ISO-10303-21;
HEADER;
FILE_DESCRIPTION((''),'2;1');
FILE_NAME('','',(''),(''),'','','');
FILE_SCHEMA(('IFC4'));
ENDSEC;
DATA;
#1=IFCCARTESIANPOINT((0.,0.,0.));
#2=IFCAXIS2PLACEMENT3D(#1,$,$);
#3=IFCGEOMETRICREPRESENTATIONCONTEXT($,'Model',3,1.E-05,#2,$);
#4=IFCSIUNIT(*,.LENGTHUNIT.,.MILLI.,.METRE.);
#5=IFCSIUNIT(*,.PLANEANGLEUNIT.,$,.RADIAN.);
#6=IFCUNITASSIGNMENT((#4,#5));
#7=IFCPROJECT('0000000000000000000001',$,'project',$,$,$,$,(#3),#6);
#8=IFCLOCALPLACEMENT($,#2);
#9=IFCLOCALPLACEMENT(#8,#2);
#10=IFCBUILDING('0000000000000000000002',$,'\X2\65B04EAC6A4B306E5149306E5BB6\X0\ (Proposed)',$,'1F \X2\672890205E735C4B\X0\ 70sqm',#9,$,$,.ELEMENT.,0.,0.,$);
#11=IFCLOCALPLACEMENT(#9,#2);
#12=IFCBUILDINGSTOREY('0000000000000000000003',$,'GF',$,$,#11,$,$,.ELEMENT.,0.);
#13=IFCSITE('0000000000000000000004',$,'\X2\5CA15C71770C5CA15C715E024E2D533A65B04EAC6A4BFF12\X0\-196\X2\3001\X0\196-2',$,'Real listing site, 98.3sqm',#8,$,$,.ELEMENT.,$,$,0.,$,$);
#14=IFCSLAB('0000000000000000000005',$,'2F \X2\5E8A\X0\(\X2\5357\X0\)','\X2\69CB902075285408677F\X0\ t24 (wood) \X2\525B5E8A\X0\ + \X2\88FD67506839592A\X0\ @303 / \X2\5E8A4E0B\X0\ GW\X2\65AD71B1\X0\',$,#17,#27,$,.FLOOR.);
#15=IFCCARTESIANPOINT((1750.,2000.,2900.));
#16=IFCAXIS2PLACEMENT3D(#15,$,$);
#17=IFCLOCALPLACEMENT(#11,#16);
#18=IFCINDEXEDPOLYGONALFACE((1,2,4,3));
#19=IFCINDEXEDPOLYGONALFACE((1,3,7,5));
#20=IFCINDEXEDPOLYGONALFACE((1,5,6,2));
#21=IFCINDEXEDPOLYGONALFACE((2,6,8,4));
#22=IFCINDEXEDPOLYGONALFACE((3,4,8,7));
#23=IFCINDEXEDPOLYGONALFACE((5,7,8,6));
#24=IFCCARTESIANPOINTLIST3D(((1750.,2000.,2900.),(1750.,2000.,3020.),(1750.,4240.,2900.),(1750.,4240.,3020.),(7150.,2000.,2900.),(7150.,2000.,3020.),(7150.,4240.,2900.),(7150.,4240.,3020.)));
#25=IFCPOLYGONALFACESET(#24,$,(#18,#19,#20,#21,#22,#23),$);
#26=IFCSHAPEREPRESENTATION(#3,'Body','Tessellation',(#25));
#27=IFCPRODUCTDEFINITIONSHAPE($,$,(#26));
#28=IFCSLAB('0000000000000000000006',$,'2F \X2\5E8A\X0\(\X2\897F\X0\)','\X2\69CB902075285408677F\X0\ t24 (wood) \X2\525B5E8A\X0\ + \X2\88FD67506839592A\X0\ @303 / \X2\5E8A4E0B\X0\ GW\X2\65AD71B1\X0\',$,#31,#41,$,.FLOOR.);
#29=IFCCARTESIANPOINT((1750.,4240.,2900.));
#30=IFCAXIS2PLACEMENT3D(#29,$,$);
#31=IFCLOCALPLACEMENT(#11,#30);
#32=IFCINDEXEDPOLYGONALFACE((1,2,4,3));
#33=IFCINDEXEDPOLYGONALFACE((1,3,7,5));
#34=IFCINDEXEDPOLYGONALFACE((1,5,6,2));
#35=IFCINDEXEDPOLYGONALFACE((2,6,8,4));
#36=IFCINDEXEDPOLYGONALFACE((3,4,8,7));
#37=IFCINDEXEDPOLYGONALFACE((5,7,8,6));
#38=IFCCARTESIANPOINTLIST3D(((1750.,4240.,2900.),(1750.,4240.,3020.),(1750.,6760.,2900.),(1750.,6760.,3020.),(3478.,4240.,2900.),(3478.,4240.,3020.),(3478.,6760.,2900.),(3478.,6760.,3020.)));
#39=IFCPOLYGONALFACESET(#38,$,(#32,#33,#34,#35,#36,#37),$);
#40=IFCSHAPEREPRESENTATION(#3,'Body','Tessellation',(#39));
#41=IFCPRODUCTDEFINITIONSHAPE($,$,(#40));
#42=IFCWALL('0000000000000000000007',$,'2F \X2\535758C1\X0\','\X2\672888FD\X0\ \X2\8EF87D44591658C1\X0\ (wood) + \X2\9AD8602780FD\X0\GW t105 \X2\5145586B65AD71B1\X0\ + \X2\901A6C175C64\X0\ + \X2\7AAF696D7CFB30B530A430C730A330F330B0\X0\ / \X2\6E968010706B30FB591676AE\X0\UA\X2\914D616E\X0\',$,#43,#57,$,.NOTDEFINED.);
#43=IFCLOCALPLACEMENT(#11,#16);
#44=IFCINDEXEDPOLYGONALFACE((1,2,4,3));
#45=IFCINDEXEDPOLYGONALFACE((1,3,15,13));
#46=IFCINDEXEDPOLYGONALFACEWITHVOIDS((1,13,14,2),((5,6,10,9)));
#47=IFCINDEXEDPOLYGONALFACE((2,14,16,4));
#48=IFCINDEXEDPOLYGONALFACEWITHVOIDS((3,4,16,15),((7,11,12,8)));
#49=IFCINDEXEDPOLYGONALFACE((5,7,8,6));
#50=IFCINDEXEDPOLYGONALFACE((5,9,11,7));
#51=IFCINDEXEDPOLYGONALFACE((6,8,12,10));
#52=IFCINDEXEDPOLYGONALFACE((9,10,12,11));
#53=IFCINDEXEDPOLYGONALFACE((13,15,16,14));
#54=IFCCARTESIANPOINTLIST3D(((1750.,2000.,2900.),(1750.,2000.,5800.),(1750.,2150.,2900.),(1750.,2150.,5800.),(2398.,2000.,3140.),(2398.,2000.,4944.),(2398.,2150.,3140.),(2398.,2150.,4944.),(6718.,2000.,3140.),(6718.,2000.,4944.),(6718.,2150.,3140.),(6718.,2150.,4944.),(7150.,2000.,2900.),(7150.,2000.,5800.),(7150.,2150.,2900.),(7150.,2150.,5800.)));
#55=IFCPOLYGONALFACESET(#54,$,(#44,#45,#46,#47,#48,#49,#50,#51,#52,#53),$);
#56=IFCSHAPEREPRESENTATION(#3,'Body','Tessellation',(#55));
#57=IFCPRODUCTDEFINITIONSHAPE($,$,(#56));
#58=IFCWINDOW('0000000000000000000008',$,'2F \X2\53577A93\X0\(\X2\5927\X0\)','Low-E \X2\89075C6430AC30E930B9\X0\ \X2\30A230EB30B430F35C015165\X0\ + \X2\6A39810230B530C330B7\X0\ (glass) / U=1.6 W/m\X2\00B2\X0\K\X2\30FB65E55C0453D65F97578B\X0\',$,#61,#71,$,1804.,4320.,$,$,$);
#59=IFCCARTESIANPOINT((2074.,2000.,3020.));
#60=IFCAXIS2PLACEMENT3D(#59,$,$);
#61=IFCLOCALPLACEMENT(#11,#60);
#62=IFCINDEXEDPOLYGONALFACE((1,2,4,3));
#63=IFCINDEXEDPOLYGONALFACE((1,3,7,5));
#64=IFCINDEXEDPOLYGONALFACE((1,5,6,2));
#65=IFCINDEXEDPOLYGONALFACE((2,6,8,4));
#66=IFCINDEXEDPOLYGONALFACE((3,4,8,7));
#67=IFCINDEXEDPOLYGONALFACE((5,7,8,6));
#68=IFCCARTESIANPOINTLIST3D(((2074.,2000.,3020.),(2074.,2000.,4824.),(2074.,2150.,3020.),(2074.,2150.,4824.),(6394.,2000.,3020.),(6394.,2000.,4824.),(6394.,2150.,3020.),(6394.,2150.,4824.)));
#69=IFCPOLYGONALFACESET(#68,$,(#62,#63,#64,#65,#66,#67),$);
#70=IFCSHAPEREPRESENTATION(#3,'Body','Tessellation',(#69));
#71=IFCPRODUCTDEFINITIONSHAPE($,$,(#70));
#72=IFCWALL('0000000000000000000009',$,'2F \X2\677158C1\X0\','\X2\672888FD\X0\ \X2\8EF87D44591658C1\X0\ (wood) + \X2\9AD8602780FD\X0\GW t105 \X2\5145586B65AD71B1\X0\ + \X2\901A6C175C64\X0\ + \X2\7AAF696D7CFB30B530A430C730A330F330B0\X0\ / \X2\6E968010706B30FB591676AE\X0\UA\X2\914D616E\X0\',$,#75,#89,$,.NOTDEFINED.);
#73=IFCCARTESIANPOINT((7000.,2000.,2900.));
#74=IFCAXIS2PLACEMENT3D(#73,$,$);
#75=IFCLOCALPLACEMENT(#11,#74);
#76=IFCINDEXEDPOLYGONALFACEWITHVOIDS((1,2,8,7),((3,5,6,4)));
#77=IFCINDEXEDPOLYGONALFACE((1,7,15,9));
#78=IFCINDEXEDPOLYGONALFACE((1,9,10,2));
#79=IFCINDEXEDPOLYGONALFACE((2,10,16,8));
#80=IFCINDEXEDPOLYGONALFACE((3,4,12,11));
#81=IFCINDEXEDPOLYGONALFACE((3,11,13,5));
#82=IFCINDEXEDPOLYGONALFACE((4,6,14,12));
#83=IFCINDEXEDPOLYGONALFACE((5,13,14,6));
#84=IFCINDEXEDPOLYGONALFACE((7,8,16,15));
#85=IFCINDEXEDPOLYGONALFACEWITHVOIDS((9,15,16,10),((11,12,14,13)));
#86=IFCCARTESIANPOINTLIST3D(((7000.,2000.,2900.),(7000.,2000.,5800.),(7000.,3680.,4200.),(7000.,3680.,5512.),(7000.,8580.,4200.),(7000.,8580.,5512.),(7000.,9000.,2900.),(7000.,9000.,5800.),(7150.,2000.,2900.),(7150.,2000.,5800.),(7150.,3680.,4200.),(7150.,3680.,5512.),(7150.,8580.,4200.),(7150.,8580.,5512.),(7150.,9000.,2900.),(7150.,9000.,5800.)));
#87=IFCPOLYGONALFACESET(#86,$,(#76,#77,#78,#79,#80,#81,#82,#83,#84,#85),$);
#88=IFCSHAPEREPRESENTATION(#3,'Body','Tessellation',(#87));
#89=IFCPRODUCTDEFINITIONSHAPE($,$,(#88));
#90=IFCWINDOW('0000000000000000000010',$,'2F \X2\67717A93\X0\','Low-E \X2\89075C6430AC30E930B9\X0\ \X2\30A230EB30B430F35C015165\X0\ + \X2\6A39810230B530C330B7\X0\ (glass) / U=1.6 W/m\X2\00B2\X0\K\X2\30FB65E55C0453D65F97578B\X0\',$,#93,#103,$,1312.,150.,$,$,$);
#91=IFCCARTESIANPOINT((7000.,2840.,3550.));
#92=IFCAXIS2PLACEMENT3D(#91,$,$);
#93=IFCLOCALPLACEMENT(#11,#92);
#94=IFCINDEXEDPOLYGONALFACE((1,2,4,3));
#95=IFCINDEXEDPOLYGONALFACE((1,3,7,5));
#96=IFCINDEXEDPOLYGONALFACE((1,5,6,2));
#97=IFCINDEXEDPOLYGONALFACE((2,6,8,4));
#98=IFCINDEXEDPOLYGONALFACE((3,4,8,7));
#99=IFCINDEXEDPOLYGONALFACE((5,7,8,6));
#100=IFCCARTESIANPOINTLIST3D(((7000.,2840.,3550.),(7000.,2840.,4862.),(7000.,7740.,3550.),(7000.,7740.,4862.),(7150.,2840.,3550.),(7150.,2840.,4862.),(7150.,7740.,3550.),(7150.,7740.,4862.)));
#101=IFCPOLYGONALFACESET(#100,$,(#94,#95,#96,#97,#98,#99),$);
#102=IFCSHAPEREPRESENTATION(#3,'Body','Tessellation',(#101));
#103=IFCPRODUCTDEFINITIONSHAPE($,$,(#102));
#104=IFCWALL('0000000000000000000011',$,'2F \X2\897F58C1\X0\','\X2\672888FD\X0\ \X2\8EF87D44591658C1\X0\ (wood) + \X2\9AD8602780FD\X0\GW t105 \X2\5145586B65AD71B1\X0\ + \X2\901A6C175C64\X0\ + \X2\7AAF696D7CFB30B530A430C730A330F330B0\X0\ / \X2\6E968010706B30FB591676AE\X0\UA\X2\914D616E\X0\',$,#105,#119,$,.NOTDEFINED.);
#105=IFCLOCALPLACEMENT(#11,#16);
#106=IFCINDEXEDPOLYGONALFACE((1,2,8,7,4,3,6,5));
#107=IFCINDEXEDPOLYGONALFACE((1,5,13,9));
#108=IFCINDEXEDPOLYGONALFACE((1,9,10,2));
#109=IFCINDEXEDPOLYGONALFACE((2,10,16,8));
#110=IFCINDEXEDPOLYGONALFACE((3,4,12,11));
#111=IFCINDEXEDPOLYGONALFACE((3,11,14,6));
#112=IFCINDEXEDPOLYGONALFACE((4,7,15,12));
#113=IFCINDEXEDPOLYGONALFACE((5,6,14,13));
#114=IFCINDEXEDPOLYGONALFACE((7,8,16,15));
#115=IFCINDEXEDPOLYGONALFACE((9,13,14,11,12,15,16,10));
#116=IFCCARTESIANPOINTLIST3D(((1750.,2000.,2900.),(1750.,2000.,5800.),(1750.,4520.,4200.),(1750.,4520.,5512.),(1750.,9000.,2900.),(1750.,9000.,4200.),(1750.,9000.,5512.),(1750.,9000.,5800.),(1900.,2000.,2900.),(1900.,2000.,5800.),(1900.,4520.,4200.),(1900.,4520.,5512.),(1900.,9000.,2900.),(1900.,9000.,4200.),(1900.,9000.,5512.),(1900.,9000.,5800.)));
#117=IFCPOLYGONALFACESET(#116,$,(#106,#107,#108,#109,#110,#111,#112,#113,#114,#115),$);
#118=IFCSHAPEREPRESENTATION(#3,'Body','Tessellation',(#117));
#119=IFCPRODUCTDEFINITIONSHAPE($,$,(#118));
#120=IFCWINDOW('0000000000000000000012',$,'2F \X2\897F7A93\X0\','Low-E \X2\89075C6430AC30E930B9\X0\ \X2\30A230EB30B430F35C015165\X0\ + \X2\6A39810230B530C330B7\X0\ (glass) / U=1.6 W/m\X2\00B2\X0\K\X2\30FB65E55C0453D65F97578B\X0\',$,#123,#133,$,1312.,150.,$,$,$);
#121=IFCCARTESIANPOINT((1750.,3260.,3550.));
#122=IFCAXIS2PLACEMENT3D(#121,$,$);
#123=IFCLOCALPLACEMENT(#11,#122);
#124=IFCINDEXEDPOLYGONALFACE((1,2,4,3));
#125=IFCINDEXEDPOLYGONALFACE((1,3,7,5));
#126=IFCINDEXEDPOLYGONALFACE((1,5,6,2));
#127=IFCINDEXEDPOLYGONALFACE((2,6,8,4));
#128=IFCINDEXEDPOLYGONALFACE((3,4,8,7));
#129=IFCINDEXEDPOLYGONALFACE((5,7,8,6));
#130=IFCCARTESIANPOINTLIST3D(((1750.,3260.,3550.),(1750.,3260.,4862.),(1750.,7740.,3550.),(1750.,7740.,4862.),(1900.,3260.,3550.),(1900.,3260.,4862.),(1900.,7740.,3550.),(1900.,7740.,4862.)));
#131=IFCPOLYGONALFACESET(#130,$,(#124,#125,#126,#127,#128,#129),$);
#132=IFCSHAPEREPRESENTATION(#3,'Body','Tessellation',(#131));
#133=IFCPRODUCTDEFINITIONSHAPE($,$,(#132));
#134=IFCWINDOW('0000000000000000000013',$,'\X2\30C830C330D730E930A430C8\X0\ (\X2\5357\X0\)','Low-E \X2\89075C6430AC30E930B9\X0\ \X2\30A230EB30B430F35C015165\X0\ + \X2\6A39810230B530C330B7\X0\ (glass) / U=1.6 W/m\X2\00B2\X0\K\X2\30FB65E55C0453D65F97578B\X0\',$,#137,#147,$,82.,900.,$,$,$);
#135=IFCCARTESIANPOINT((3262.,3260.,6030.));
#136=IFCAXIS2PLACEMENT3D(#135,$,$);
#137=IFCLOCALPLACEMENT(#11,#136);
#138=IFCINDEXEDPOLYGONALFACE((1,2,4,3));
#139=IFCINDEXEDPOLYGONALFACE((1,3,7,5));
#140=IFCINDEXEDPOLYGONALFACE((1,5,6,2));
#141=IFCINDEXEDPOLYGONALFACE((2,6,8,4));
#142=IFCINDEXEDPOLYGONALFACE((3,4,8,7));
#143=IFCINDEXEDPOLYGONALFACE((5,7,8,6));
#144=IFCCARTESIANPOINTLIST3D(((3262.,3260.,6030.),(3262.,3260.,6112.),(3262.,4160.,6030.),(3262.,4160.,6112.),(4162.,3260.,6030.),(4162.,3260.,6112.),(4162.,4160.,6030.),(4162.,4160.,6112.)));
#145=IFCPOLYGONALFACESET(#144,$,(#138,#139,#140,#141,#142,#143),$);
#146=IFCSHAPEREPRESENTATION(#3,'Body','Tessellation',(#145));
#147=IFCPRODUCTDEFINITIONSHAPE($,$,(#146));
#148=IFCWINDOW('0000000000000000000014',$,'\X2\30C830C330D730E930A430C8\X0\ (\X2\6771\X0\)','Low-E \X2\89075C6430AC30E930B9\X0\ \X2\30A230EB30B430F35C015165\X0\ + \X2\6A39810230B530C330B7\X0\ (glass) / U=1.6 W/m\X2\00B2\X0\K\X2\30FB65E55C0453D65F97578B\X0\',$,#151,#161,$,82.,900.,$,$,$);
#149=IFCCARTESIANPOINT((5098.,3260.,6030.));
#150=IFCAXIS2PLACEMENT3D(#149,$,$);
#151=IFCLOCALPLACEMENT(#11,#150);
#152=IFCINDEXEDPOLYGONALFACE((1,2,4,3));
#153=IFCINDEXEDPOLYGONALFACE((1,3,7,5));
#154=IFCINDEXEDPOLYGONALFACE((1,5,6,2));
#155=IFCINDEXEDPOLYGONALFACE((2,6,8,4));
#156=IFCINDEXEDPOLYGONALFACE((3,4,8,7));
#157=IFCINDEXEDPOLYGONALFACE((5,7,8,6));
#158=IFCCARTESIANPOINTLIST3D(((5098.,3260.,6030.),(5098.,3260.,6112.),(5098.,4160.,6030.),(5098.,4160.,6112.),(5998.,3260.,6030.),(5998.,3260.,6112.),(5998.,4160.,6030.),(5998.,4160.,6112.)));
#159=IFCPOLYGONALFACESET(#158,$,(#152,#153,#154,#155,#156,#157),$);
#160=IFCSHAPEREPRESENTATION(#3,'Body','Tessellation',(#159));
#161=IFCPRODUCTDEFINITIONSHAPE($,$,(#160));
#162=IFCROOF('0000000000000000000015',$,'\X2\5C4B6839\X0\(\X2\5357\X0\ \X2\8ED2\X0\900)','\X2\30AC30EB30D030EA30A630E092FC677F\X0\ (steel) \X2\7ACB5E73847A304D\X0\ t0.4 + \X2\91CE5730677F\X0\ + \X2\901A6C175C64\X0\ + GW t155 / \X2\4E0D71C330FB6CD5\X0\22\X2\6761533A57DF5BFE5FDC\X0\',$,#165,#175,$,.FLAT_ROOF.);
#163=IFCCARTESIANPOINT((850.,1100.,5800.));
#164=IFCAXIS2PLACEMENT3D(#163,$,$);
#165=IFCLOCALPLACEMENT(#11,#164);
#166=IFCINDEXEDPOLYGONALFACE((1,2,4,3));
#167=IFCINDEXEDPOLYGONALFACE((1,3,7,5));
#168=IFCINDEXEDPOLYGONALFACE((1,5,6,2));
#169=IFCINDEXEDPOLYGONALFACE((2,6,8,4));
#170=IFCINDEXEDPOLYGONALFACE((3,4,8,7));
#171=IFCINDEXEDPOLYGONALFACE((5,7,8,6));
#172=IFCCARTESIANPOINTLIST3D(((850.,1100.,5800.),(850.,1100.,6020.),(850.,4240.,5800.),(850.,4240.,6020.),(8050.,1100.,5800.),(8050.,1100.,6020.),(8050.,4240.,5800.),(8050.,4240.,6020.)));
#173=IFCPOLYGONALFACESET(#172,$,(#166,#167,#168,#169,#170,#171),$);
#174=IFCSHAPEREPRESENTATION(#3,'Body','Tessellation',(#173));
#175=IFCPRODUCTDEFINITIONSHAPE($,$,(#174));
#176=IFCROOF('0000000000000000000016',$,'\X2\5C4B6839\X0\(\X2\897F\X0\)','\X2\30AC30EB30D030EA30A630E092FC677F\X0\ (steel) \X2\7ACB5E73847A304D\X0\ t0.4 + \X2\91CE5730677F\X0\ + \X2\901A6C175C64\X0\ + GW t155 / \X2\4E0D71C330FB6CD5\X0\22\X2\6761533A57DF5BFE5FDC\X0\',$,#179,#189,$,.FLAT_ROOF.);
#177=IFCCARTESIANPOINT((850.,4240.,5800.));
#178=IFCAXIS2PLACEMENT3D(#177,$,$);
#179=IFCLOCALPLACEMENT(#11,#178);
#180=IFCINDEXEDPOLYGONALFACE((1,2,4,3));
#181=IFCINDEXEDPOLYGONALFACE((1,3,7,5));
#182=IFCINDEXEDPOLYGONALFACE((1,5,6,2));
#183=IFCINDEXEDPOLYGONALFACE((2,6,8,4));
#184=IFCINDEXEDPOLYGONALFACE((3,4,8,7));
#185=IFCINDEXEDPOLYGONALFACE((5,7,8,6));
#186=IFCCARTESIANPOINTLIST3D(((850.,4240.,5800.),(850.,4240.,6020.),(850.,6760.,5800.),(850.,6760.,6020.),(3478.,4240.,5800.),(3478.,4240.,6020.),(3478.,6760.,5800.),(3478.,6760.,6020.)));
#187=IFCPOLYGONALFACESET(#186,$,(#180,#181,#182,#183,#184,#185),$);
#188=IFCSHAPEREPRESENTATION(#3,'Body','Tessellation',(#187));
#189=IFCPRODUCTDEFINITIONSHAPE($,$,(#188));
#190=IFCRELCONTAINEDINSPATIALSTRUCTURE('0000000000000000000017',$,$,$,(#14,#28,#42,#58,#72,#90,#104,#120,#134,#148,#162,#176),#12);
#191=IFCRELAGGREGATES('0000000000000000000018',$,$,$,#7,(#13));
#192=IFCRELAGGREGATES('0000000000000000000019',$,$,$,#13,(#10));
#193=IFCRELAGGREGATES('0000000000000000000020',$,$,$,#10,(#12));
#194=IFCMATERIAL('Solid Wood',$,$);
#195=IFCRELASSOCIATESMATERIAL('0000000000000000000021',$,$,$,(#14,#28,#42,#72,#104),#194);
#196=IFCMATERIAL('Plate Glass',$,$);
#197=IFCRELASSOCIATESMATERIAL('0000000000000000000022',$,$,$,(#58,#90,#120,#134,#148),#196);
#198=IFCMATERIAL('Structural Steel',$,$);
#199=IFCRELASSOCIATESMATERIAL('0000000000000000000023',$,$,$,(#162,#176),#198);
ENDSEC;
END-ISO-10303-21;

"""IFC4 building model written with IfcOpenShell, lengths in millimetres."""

from ifc_helpers import new_model, si_unit, frame, frame_2d, origin, place, context, project, spatial, rectangle, extrude, material, element, fill, save


model = new_model("IFC4")

# Units and contexts
model_context = context("Model", 3, precision=1e-05, world=origin())
ifc_project = project(units=[si_unit("LENGTHUNIT", "METRE", prefix="MILLI"), si_unit("PLANEANGLEUNIT", "RADIAN")], contexts=[model_context])

# Site, building, storey
site_placement = place(None, origin())
site = spatial("IfcSite", under=ifc_project, at=site_placement, Name="岡山県岡山市中区新京橋２-196、196-2", ObjectType="Real listing site, 98.3sqm", CompositionType="ELEMENT", RefElevation=0.0)
building_placement = place(site_placement, origin())
building = spatial("IfcBuilding", under=site, at=building_placement, Name="新京橋の光の家 (Proposed)", ObjectType="1F 木造平屋 70sqm", CompositionType="ELEMENT", ElevationOfRefHeight=0.0, ElevationOfTerrain=0.0)
storey_placement = place(building_placement, origin())
storey = spatial("IfcBuildingStorey", under=building, at=storey_placement, Name="GF", CompositionType="ELEMENT", Elevation=0.0)

# Slabs
ifc_material_1 = material(Name="Solid Wood")
slab_1_placement = place(storey_placement, frame((1750.0, 2000.0, 2900.0)))
element("IfcSlab", 1, at=slab_1_placement, inside=storey, material=ifc_material_1, Name="2F 床(南)", Description="構造用合板 t24 (wood) 剛床 + 製材根太 @303 / 床下 GW断熱", PredefinedType="FLOOR", context=model_context, shape_type="SweptSolid", body=[
    extrude(rectangle(XDim=5400.0, YDim=2240.0, at=frame_2d((2700.0, 1120.0))), frame((1750.0, 2000.0, 2900.0)), (0.0, 0.0, 1.0), 120.0),
])
slab_2_placement = place(storey_placement, frame((1750.0, 4240.0, 2900.0)))
element("IfcSlab", 2, at=slab_2_placement, inside=storey, material=ifc_material_1, Name="2F 床(西)", Description="構造用合板 t24 (wood) 剛床 + 製材根太 @303 / 床下 GW断熱", PredefinedType="FLOOR", context=model_context, shape_type="SweptSolid", body=[
    extrude(rectangle(XDim=1728.0, YDim=2520.0, at=frame_2d((864.0, 1260.0))), frame((1750.0, 4240.0, 2900.0)), (0.0, 0.0, 1.0), 120.0),
])

# Walls, openings, windows
wall_1_placement = place(storey_placement, frame((1750.0, 2000.0, 2900.0)))
wall_1 = element("IfcWall", 3, at=wall_1_placement, inside=storey, material=ifc_material_1, Name="2F 南壁", Description="木製 軸組外壁 (wood) + 高性能GW t105 充填断熱 + 通気層 + 窯業系サイディング / 準耐火・外皮UA配慮", PredefinedType="NOTDEFINED", context=model_context, shape_type="SweptSolid", body=[
    extrude(rectangle(XDim=5400.0, YDim=150.0, at=frame_2d((2700.0, 75.0))), frame((1750.0, 2000.0, 2900.0)), (0.0, 0.0, 1.0), 2900.0),
])
opening_1_placement = place(storey_placement, frame((2074.0, 2000.0, 3020.0)))
opening_1 = element("IfcOpeningElement", 4, at=opening_1_placement, cuts=wall_1, PredefinedType="NOTDEFINED", context=model_context, shape_type="SweptSolid", body=[
    extrude(rectangle(XDim=4320.0, YDim=150.0, at=frame_2d((2160.0, 75.0))), frame((2074.0, 2000.0, 3020.0)), (0.0, 0.0, 1.0), 1804.0),
])
ifc_material_2 = material(Name="Plate Glass")
window_1_placement = place(storey_placement, frame((2074.0, 2000.0, 3020.0)))
window_1 = element("IfcWindow", 5, at=window_1_placement, inside=storey, material=ifc_material_2, Name="2F 南窓(大)", Description="Low-E 複層ガラス アルゴン封入 + 樹脂サッシ (glass) / U=1.6 W/m²K・日射取得型", OverallHeight=1804.0, OverallWidth=4320.0, context=model_context, shape_type="SweptSolid", body=[
    extrude(rectangle(XDim=4320.0, YDim=150.0, at=frame_2d((2160.0, 75.0))), frame((2074.0, 2000.0, 3020.0)), (0.0, 0.0, 1.0), 1804.0),
])
fill(opening_1, window_1)
wall_2_placement = place(storey_placement, frame((7000.0, 2000.0, 2900.0)))
wall_2 = element("IfcWall", 6, at=wall_2_placement, inside=storey, material=ifc_material_1, Name="2F 東壁", Description="木製 軸組外壁 (wood) + 高性能GW t105 充填断熱 + 通気層 + 窯業系サイディング / 準耐火・外皮UA配慮", PredefinedType="NOTDEFINED", context=model_context, shape_type="SweptSolid", body=[
    extrude(rectangle(XDim=150.0, YDim=7000.0, at=frame_2d((75.0, 3500.0))), frame((7000.0, 2000.0, 2900.0)), (0.0, 0.0, 1.0), 2900.0),
])
opening_2_placement = place(storey_placement, frame((7000.0, 2840.0, 3550.0)))
opening_2 = element("IfcOpeningElement", 7, at=opening_2_placement, cuts=wall_2, PredefinedType="NOTDEFINED", context=model_context, shape_type="SweptSolid", body=[
    extrude(rectangle(XDim=150.0, YDim=4900.0, at=frame_2d((75.0, 2450.0))), frame((7000.0, 2840.0, 3550.0)), (0.0, 0.0, 1.0), 1312.0),
])
window_2_placement = place(storey_placement, frame((7000.0, 2840.0, 3550.0)))
window_2 = element("IfcWindow", 8, at=window_2_placement, inside=storey, material=ifc_material_2, Name="2F 東窓", Description="Low-E 複層ガラス アルゴン封入 + 樹脂サッシ (glass) / U=1.6 W/m²K・日射取得型", OverallHeight=1312.0, OverallWidth=150.0, context=model_context, shape_type="SweptSolid", body=[
    extrude(rectangle(XDim=150.0, YDim=4900.0, at=frame_2d((75.0, 2450.0))), frame((7000.0, 2840.0, 3550.0)), (0.0, 0.0, 1.0), 1312.0),
])
fill(opening_2, window_2)
wall_3_placement = place(storey_placement, frame((1750.0, 2000.0, 2900.0)))
wall_3 = element("IfcWall", 9, at=wall_3_placement, inside=storey, material=ifc_material_1, Name="2F 西壁", Description="木製 軸組外壁 (wood) + 高性能GW t105 充填断熱 + 通気層 + 窯業系サイディング / 準耐火・外皮UA配慮", PredefinedType="NOTDEFINED", context=model_context, shape_type="SweptSolid", body=[
    extrude(rectangle(XDim=150.0, YDim=7000.0, at=frame_2d((75.0, 3500.0))), frame((1750.0, 2000.0, 2900.0)), (0.0, 0.0, 1.0), 2900.0),
])
opening_3_placement = place(storey_placement, frame((1750.0, 3260.0, 3550.0)))
opening_3 = element("IfcOpeningElement", 10, at=opening_3_placement, cuts=wall_3, PredefinedType="NOTDEFINED", context=model_context, shape_type="SweptSolid", body=[
    extrude(rectangle(XDim=150.0, YDim=4480.0, at=frame_2d((75.0, 2240.0))), frame((1750.0, 3260.0, 3550.0)), (0.0, 0.0, 1.0), 1312.0),
])
window_3_placement = place(storey_placement, frame((1750.0, 3260.0, 3550.0)))
window_3 = element("IfcWindow", 11, at=window_3_placement, inside=storey, material=ifc_material_2, Name="2F 西窓", Description="Low-E 複層ガラス アルゴン封入 + 樹脂サッシ (glass) / U=1.6 W/m²K・日射取得型", OverallHeight=1312.0, OverallWidth=150.0, context=model_context, shape_type="SweptSolid", body=[
    extrude(rectangle(XDim=150.0, YDim=4480.0, at=frame_2d((75.0, 2240.0))), frame((1750.0, 3260.0, 3550.0)), (0.0, 0.0, 1.0), 1312.0),
])
fill(opening_3, window_3)

# Windows
window_4_placement = place(storey_placement, frame((3262.0, 3260.0, 6030.0)))
element("IfcWindow", 12, at=window_4_placement, inside=storey, material=ifc_material_2, Name="トップライト (南)", Description="Low-E 複層ガラス アルゴン封入 + 樹脂サッシ (glass) / U=1.6 W/m²K・日射取得型", OverallHeight=82.0, OverallWidth=900.0, context=model_context, shape_type="SweptSolid", body=[
    extrude(rectangle(XDim=900.0, YDim=900.0, at=frame_2d((450.0, 450.0))), frame((3262.0, 3260.0, 6030.0)), (0.0, 0.0, 1.0), 82.0),
])
window_5_placement = place(storey_placement, frame((5098.0, 3260.0, 6030.0)))
element("IfcWindow", 13, at=window_5_placement, inside=storey, material=ifc_material_2, Name="トップライト (東)", Description="Low-E 複層ガラス アルゴン封入 + 樹脂サッシ (glass) / U=1.6 W/m²K・日射取得型", OverallHeight=82.0, OverallWidth=900.0, context=model_context, shape_type="SweptSolid", body=[
    extrude(rectangle(XDim=900.0, YDim=900.0, at=frame_2d((450.0, 450.0))), frame((5098.0, 3260.0, 6030.0)), (0.0, 0.0, 1.0), 82.0),
])

# Roofs
ifc_material_3 = material(Name="Structural Steel")
roof_1_placement = place(storey_placement, frame((850.0, 1100.0, 5800.0)))
element("IfcRoof", 14, at=roof_1_placement, inside=storey, material=ifc_material_3, Name="屋根(南 軒900)", Description="ガルバリウム鋼板 (steel) 立平葺き t0.4 + 野地板 + 通気層 + GW t155 / 不燃・法22条区域対応", PredefinedType="FLAT_ROOF", context=model_context, shape_type="SweptSolid", body=[
    extrude(rectangle(XDim=7200.0, YDim=3140.0, at=frame_2d((3600.0, 1570.0))), frame((850.0, 1100.0, 5800.0)), (0.0, 0.0, 1.0), 220.0),
])
roof_2_placement = place(storey_placement, frame((850.0, 4240.0, 5800.0)))
element("IfcRoof", 15, at=roof_2_placement, inside=storey, material=ifc_material_3, Name="屋根(西)", Description="ガルバリウム鋼板 (steel) 立平葺き t0.4 + 野地板 + 通気層 + GW t155 / 不燃・法22条区域対応", PredefinedType="FLAT_ROOF", context=model_context, shape_type="SweptSolid", body=[
    extrude(rectangle(XDim=2628.0, YDim=2520.0, at=frame_2d((1314.0, 1260.0))), frame((850.0, 4240.0, 5800.0)), (0.0, 0.0, 1.0), 220.0),
])

save(model, "model.ifc")
